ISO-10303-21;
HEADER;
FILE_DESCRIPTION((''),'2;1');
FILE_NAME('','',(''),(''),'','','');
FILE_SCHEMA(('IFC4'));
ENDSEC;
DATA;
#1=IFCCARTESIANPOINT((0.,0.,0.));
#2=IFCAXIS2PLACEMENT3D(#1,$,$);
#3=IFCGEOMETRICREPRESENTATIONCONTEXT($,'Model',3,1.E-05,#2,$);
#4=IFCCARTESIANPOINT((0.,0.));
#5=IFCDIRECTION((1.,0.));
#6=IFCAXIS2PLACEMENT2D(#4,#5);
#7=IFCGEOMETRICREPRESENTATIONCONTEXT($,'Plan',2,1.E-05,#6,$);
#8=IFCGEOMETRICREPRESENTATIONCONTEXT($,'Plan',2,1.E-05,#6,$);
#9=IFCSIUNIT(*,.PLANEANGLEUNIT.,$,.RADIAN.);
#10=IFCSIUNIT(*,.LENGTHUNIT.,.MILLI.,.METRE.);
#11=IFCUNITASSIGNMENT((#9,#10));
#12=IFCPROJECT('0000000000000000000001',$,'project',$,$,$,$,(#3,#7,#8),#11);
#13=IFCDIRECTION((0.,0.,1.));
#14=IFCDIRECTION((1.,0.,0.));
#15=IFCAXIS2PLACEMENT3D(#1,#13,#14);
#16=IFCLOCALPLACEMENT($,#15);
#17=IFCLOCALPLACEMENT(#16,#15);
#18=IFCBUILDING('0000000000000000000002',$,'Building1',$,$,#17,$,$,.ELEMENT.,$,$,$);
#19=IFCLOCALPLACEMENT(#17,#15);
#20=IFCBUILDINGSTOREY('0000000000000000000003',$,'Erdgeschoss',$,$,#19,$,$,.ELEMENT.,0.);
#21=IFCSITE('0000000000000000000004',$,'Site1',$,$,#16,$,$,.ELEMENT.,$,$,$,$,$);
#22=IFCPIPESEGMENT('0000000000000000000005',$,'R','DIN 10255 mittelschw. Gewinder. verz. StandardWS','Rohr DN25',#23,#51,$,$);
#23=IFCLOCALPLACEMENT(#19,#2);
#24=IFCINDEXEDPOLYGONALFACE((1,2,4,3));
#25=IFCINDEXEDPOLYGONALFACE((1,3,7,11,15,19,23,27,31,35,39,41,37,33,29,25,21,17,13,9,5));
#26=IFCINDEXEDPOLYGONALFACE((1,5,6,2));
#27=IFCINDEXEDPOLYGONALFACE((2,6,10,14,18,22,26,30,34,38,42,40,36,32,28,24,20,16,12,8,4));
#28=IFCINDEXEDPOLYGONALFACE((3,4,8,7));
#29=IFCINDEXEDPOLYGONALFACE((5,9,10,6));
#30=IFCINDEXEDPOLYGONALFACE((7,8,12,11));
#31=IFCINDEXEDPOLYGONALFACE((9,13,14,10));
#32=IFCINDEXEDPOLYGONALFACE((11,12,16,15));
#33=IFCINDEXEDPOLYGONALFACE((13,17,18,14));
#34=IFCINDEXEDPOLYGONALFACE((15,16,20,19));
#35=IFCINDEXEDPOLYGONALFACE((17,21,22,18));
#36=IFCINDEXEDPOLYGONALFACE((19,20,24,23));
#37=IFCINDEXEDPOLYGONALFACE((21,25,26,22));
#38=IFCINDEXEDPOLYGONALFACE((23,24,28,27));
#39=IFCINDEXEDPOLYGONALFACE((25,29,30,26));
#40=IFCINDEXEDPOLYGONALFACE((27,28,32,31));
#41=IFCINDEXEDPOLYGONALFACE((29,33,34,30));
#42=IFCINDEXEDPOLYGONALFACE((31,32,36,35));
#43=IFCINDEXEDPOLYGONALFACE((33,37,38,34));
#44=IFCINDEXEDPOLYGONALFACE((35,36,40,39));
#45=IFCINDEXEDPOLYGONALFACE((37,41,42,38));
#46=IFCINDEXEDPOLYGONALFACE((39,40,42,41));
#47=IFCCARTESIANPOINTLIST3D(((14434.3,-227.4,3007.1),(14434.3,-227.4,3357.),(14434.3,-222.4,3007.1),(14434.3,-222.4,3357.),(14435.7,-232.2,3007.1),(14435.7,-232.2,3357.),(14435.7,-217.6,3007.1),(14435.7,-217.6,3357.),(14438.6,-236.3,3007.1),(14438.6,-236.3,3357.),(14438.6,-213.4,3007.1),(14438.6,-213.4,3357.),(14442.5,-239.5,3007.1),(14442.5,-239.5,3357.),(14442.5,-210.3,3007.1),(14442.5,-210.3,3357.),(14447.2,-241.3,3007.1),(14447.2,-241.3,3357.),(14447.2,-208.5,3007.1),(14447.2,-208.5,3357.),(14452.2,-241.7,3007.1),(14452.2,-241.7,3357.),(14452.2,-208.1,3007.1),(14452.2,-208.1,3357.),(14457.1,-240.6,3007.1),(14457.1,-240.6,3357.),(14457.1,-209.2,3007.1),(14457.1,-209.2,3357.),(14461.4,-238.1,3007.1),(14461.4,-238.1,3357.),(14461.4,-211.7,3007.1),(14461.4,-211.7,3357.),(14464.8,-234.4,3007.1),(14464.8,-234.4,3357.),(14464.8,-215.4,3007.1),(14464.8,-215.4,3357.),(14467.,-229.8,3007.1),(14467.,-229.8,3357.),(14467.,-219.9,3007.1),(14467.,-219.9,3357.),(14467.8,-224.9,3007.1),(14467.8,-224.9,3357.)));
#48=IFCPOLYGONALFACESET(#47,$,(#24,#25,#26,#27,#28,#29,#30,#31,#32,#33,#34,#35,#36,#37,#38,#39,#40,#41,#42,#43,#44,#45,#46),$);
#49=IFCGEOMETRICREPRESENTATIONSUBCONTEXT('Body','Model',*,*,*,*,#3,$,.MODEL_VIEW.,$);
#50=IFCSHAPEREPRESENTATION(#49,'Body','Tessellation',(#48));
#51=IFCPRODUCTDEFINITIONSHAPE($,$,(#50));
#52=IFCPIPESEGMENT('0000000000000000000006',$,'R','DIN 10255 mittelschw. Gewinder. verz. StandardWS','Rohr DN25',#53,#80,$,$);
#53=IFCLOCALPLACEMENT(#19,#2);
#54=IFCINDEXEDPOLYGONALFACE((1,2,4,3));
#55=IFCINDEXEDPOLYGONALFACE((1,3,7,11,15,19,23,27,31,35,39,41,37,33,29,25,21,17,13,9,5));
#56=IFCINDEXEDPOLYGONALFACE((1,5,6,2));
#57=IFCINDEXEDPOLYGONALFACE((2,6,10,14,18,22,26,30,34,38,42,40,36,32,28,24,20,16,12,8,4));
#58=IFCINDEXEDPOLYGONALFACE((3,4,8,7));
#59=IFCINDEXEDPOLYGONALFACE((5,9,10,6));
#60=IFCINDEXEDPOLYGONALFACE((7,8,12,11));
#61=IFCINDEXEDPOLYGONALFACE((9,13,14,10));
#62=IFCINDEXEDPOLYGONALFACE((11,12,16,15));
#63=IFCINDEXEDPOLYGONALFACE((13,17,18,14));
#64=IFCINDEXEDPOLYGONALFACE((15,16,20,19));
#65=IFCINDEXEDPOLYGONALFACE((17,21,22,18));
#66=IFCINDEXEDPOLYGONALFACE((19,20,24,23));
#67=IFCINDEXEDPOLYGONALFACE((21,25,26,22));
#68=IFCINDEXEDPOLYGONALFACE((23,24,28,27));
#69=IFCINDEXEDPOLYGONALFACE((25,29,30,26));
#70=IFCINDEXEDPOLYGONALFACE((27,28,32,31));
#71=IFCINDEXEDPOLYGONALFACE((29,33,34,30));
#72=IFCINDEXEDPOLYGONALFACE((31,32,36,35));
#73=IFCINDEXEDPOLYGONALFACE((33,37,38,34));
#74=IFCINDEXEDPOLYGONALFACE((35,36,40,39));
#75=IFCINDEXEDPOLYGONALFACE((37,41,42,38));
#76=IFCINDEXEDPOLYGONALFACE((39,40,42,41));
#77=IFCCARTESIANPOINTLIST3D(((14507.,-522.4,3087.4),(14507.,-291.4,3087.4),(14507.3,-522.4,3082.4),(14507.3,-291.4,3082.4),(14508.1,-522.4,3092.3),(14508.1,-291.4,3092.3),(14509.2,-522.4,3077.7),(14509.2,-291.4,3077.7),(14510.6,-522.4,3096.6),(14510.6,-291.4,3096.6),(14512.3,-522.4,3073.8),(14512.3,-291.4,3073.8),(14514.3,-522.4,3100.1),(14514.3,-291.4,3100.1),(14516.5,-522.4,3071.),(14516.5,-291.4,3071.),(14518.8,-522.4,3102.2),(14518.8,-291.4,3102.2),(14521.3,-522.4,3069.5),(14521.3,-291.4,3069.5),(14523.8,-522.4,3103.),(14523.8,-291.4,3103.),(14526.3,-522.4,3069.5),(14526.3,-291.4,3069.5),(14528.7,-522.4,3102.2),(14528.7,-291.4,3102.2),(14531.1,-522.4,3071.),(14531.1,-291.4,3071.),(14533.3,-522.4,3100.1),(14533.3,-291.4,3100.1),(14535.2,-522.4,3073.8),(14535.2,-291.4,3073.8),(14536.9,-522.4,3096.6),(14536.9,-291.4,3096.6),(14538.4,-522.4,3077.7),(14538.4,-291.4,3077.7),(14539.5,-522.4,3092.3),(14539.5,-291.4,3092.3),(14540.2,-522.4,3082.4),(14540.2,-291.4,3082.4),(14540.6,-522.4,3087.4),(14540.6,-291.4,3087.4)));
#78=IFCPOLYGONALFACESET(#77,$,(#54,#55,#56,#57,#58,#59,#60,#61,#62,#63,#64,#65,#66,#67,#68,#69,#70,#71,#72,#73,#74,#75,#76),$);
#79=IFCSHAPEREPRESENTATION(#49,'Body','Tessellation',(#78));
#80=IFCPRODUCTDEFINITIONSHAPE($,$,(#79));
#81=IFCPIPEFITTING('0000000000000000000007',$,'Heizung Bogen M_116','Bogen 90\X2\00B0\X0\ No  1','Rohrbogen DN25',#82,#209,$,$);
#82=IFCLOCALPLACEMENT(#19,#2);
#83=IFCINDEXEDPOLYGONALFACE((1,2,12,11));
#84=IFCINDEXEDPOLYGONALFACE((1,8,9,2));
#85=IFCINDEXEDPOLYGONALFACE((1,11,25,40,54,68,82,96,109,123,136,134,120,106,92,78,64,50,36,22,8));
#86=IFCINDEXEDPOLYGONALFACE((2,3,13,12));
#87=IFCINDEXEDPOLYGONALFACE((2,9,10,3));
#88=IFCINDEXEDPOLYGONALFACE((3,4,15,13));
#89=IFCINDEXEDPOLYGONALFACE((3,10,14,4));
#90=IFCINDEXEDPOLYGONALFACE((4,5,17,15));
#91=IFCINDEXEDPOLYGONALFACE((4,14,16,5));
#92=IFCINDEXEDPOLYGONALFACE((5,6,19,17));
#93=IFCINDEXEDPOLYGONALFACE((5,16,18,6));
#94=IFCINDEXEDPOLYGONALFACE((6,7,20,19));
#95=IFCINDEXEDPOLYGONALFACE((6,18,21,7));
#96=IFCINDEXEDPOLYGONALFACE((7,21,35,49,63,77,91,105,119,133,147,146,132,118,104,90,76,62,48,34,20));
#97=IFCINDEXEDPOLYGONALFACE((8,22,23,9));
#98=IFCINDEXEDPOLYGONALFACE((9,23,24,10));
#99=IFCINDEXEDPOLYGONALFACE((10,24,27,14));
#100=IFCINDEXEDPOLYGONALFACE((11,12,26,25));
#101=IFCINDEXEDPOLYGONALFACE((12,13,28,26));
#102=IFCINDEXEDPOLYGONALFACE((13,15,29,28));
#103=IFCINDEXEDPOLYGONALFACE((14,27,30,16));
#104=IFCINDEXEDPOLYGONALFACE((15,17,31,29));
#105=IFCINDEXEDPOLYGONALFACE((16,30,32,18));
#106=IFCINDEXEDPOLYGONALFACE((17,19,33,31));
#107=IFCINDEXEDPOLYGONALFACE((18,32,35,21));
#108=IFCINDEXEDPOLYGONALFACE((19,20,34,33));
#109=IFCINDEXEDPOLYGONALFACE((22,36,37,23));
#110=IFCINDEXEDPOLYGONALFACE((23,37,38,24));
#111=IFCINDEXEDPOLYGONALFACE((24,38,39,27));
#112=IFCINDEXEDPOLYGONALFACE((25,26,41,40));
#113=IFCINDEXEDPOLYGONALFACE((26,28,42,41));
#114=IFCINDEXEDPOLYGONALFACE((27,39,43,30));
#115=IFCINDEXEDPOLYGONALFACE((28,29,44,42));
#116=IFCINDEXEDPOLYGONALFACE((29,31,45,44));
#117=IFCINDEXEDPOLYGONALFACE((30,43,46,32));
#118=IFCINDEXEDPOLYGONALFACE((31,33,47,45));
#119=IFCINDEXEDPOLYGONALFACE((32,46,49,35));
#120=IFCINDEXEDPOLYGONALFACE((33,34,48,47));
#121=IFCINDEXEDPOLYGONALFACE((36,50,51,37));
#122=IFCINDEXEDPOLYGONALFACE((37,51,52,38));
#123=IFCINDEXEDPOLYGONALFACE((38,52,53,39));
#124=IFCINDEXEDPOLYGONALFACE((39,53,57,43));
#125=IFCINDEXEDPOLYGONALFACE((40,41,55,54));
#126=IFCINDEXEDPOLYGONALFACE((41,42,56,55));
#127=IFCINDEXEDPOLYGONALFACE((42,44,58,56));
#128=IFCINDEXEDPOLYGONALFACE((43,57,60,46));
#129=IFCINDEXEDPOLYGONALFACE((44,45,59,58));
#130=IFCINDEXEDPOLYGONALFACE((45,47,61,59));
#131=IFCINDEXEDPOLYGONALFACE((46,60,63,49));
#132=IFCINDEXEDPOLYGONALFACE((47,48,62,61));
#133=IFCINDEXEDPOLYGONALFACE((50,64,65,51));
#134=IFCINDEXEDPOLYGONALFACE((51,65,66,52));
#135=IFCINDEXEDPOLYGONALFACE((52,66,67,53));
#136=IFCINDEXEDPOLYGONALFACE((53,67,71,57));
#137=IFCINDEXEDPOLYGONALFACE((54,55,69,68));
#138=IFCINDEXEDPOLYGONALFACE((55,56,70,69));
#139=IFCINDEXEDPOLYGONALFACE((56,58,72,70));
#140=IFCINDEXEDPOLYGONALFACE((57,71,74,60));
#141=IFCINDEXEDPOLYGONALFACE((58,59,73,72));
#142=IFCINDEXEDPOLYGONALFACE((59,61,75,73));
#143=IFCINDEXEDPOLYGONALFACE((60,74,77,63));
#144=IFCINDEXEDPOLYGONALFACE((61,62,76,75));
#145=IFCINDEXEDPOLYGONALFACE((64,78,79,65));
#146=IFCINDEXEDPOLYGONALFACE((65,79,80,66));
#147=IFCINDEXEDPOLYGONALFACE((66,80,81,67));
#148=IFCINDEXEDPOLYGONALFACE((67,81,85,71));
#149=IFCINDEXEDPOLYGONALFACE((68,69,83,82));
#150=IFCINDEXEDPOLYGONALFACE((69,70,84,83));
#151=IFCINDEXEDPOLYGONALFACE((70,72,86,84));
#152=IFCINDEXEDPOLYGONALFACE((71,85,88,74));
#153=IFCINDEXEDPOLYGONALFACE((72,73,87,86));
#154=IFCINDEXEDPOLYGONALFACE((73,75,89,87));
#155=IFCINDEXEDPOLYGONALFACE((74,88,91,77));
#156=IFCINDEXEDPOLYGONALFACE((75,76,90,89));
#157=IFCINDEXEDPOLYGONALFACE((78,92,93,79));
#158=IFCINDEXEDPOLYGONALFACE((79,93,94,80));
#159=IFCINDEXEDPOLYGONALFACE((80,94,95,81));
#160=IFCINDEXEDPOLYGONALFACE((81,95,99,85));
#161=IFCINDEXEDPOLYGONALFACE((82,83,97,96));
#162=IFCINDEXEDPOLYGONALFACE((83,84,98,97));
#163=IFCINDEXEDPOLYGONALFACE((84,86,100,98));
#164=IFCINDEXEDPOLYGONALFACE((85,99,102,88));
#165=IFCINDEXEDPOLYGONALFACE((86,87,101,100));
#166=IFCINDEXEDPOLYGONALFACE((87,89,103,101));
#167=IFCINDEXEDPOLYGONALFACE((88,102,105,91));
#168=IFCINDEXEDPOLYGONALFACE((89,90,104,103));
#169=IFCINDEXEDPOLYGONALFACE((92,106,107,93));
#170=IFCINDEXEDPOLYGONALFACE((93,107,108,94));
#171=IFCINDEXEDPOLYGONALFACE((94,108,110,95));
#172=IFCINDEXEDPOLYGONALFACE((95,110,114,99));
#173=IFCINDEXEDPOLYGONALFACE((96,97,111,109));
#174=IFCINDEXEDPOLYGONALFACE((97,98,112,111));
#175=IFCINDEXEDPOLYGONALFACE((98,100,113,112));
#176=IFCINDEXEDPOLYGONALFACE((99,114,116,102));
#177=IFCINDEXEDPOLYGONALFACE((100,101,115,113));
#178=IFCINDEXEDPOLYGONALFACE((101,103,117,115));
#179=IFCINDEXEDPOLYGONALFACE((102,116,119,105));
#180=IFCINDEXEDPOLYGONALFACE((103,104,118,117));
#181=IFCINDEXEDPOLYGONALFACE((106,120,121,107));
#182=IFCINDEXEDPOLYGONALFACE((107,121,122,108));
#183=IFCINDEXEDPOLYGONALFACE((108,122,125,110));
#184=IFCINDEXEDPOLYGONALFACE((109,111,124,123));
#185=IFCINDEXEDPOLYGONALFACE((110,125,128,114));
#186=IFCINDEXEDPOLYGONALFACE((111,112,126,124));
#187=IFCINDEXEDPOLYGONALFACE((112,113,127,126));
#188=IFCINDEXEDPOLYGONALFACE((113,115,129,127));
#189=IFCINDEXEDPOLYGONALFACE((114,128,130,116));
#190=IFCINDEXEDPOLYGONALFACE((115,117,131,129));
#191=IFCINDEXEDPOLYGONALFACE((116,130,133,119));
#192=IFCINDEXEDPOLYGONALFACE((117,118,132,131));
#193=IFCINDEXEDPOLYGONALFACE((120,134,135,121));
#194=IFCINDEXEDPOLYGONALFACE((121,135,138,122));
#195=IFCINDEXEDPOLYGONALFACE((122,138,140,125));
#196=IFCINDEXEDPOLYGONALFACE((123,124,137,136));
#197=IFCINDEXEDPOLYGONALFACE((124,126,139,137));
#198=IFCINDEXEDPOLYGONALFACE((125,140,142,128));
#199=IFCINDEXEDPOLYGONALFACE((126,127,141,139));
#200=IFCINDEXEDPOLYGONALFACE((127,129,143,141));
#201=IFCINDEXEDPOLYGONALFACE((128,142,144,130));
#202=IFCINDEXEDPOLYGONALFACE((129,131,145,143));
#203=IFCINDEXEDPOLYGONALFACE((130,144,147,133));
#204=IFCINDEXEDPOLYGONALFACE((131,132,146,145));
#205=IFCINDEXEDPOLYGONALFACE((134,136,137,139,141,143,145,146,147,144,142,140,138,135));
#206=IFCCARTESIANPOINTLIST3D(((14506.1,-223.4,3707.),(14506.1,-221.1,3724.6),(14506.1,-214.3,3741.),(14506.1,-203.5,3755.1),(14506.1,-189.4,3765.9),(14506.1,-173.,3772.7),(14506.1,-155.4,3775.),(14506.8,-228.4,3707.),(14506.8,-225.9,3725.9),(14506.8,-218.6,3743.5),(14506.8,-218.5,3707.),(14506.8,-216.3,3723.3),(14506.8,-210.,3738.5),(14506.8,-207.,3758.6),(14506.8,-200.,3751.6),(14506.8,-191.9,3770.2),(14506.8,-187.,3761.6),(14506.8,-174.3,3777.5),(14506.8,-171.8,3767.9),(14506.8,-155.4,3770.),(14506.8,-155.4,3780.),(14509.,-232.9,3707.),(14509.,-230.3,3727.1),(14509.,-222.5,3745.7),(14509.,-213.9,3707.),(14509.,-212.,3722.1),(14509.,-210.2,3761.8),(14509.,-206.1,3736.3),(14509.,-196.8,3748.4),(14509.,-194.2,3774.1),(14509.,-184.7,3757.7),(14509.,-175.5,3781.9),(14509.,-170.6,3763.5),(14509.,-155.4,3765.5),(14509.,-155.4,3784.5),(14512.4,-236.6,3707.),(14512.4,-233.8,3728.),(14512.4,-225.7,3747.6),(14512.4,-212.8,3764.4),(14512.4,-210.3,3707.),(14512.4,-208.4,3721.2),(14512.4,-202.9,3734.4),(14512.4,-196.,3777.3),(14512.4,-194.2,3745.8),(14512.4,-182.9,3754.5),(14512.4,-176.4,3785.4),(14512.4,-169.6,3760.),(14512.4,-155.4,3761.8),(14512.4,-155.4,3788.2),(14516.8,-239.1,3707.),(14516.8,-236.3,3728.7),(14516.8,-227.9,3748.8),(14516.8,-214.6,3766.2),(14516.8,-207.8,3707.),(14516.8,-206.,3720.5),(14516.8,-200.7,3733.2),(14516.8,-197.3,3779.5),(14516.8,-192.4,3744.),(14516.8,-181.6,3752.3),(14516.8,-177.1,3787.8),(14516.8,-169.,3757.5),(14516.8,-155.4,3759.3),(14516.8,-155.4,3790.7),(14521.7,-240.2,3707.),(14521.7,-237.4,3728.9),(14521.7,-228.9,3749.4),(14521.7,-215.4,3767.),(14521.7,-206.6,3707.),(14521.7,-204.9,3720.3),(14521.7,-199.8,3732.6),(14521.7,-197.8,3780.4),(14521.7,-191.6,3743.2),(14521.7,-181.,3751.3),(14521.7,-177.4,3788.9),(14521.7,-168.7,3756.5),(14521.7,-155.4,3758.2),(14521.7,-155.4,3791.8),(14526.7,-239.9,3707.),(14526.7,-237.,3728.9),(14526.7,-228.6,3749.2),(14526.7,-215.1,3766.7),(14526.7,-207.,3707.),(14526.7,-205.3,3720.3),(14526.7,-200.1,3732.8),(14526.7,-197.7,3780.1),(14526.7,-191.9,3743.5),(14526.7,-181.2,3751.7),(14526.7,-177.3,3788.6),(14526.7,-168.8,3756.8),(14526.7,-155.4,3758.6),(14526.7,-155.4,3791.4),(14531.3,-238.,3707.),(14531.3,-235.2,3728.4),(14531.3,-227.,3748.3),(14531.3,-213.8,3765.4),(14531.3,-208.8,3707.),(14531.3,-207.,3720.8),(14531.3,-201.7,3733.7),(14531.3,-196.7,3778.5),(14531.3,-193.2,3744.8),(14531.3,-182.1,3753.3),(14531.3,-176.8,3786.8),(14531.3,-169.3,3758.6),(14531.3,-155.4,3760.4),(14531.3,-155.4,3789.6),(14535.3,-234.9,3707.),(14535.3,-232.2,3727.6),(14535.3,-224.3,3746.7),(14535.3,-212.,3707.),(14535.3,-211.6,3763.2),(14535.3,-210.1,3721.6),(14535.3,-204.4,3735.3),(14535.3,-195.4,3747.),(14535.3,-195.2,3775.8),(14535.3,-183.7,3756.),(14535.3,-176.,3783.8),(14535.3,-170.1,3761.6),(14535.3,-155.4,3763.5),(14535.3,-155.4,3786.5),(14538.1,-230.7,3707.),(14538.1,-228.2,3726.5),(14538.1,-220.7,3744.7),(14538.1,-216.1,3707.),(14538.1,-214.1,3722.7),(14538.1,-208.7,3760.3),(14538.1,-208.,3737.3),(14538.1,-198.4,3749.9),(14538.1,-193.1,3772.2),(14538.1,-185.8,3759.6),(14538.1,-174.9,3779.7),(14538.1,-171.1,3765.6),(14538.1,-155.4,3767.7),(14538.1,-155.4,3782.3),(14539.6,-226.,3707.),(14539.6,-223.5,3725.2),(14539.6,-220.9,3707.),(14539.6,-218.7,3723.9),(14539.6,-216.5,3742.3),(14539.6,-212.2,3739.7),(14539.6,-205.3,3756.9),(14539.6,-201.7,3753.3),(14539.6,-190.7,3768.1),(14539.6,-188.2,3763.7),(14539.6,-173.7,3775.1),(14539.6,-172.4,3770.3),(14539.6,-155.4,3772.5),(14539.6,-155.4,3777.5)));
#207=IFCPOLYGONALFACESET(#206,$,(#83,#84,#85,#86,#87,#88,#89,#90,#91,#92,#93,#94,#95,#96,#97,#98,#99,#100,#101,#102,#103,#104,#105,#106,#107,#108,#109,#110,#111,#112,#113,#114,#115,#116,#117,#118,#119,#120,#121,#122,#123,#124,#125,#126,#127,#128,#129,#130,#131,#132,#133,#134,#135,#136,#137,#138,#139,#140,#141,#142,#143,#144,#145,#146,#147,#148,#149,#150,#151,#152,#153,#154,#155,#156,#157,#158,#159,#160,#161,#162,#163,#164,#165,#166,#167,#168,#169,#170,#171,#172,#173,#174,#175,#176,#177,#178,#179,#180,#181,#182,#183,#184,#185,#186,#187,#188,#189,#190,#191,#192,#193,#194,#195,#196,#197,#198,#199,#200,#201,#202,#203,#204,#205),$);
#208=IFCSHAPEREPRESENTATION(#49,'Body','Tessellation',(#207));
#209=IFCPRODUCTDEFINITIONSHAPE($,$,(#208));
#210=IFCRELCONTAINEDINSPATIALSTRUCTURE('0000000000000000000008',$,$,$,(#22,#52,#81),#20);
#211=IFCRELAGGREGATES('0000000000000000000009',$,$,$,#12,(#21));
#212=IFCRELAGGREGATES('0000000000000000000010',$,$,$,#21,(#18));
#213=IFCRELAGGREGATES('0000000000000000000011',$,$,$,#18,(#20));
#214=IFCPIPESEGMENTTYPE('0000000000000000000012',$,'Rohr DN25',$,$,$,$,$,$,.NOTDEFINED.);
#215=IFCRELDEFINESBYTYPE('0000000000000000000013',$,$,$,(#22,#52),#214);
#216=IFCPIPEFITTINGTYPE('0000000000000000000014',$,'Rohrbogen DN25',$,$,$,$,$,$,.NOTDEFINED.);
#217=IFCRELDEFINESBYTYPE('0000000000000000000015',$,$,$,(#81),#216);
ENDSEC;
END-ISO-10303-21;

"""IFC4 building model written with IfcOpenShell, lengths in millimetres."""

from ifc_helpers import new_model, entity, si_unit, frame, origin, origin_with_axes, origin_2d_with_axis, place, context, subcontext, project, spatial, circle, extrude, shape, source, transform, mapped, type_object, element, save


model = new_model("IFC4")

# Units and contexts
model_context = context("Model", 3, precision=1e-05, world=origin())
plan_context_1 = context("Plan", 2, precision=1e-05, world=origin_2d_with_axis())
plan_context_2 = context("Plan", 2, precision=1e-05, world=origin_2d_with_axis())
body_context = subcontext(model_context, "Body", "Model", "MODEL_VIEW")
ifc_project = project(units=[si_unit("PLANEANGLEUNIT", "RADIAN"), si_unit("LENGTHUNIT", "METRE", prefix="MILLI")], contexts=[model_context, plan_context_1, plan_context_2])

# Site, building, storey
site_placement = place(None, origin_with_axes())
site = spatial("IfcSite", under=ifc_project, at=site_placement, Name="Site1", CompositionType="ELEMENT")
building_placement = place(site_placement, origin_with_axes())
building = spatial("IfcBuilding", under=site, at=building_placement, Name="Building1", CompositionType="ELEMENT")
storey_placement = place(building_placement, origin_with_axes())
storey = spatial("IfcBuildingStorey", under=building, at=storey_placement, Name="Erdgeschoss", CompositionType="ELEMENT", Elevation=0.0)

# Pipe segments
pipe_segment_type_1 = type_object("IfcPipeSegmentType", Name="Rohr DN25", PredefinedType="NOTDEFINED")
pipe_segment_1_placement = place(storey_placement, frame((14450.9, -224.7, 3182.1), z_axis=(0.0, 0.0, 1.0), x_axis=(1.0, 0.0, 0.0)))
element("IfcPipeSegment", 1, at=pipe_segment_1_placement, inside=storey, type_object=pipe_segment_type_1, Name="R", Description="DIN 10255 mittelschw. Gewinder. verz. StandardWS", ObjectType="Rohr DN25", context=body_context, shape_type="SolidModel", body=[
    extrude(circle(Radius=16.9, at=origin_2d_with_axis()), frame((0.0, -0.2, 174.9), z_axis=(0.0, 0.0, -1.0), x_axis=(1.0, 0.0, 0.0)), (0.0, 0.0, 1.0), 349.9),
])
pipe_segment_2_placement = place(storey_placement, frame((14523.6, -406.9, 3086.1), z_axis=(0.0, 0.0, 1.0), x_axis=(1.0, 0.0, 0.0)))
element("IfcPipeSegment", 2, at=pipe_segment_2_placement, inside=storey, type_object=pipe_segment_type_1, Name="R", Description="DIN 10255 mittelschw. Gewinder. verz. StandardWS", ObjectType="Rohr DN25", context=body_context, shape_type="SolidModel", body=[
    extrude(circle(Radius=16.9, at=origin_2d_with_axis()), frame((0.1, -115.5, 0.0), z_axis=(0.000001, 1.0, 0.0), x_axis=(0.0, 0.0, 1.0)), (0.0, 0.0, 1.0), 231.0),
])

# Pipe fitting
pipe_fitting_type = type_object("IfcPipeFittingType", Name="Rohrbogen DN25", PredefinedType="NOTDEFINED")
shared_shape_1 = source(origin_with_axes(), body_context, "Body", "SolidModel", [
    entity("IfcRevolvedAreaSolid", entity("IfcCircleProfileDef", "AREA", None, entity("IfcAxis2Placement2D", entity("IfcCartesianPoint", [0.0, 0.0]), entity("IfcDirection", [1.0, 0.0])), 16.9), entity("IfcAxis2Placement3D", entity("IfcCartesianPoint", [-42.4, 0.0, 25.6]), entity("IfcDirection", [1.0, 0.0, 0.0]), entity("IfcDirection", [0.0, -1.0, 0.0])), entity("IfcAxis1Placement", entity("IfcCartesianPoint", [0.0, 68.0, 0.0]), entity("IfcDirection", [-1.0, 0.0, 0.0])), 1.570796),
])
pipe_fitting_1_placement = place(storey_placement, frame((14522.9, -197.9, 3749.4), z_axis=(0.0, 0.0, 1.0), x_axis=(1.0, 0.0, 0.0)))
element("IfcPipeFitting", 3, at=pipe_fitting_1_placement, inside=storey, type_object=pipe_fitting_type, Name="Heizung Bogen M_116", Description="Bogen 90° No  1", ObjectType="Rohrbogen DN25", shapes=[
    shape(body_context, "Body", "MappedRepresentation", [mapped(shared_shape_1, transform((0.0, 0.0, 0.0), x_axis=(0.0, -1.0, 0.0), y_axis=(1.0, 0.0, 0.0), z_axis=(0.0, 0.0, 1.0), scale=1.0))]),
    shape(body_context, "Body", "MappedRepresentation", [mapped(shared_shape_1, transform((0.0, 0.0, 0.0), x_axis=(0.0, -1.0, 0.0), y_axis=(1.0, 0.0, 0.0), z_axis=(0.0, 0.0, 1.0), scale=1.0))]),
])

save(model, "model.ifc")
